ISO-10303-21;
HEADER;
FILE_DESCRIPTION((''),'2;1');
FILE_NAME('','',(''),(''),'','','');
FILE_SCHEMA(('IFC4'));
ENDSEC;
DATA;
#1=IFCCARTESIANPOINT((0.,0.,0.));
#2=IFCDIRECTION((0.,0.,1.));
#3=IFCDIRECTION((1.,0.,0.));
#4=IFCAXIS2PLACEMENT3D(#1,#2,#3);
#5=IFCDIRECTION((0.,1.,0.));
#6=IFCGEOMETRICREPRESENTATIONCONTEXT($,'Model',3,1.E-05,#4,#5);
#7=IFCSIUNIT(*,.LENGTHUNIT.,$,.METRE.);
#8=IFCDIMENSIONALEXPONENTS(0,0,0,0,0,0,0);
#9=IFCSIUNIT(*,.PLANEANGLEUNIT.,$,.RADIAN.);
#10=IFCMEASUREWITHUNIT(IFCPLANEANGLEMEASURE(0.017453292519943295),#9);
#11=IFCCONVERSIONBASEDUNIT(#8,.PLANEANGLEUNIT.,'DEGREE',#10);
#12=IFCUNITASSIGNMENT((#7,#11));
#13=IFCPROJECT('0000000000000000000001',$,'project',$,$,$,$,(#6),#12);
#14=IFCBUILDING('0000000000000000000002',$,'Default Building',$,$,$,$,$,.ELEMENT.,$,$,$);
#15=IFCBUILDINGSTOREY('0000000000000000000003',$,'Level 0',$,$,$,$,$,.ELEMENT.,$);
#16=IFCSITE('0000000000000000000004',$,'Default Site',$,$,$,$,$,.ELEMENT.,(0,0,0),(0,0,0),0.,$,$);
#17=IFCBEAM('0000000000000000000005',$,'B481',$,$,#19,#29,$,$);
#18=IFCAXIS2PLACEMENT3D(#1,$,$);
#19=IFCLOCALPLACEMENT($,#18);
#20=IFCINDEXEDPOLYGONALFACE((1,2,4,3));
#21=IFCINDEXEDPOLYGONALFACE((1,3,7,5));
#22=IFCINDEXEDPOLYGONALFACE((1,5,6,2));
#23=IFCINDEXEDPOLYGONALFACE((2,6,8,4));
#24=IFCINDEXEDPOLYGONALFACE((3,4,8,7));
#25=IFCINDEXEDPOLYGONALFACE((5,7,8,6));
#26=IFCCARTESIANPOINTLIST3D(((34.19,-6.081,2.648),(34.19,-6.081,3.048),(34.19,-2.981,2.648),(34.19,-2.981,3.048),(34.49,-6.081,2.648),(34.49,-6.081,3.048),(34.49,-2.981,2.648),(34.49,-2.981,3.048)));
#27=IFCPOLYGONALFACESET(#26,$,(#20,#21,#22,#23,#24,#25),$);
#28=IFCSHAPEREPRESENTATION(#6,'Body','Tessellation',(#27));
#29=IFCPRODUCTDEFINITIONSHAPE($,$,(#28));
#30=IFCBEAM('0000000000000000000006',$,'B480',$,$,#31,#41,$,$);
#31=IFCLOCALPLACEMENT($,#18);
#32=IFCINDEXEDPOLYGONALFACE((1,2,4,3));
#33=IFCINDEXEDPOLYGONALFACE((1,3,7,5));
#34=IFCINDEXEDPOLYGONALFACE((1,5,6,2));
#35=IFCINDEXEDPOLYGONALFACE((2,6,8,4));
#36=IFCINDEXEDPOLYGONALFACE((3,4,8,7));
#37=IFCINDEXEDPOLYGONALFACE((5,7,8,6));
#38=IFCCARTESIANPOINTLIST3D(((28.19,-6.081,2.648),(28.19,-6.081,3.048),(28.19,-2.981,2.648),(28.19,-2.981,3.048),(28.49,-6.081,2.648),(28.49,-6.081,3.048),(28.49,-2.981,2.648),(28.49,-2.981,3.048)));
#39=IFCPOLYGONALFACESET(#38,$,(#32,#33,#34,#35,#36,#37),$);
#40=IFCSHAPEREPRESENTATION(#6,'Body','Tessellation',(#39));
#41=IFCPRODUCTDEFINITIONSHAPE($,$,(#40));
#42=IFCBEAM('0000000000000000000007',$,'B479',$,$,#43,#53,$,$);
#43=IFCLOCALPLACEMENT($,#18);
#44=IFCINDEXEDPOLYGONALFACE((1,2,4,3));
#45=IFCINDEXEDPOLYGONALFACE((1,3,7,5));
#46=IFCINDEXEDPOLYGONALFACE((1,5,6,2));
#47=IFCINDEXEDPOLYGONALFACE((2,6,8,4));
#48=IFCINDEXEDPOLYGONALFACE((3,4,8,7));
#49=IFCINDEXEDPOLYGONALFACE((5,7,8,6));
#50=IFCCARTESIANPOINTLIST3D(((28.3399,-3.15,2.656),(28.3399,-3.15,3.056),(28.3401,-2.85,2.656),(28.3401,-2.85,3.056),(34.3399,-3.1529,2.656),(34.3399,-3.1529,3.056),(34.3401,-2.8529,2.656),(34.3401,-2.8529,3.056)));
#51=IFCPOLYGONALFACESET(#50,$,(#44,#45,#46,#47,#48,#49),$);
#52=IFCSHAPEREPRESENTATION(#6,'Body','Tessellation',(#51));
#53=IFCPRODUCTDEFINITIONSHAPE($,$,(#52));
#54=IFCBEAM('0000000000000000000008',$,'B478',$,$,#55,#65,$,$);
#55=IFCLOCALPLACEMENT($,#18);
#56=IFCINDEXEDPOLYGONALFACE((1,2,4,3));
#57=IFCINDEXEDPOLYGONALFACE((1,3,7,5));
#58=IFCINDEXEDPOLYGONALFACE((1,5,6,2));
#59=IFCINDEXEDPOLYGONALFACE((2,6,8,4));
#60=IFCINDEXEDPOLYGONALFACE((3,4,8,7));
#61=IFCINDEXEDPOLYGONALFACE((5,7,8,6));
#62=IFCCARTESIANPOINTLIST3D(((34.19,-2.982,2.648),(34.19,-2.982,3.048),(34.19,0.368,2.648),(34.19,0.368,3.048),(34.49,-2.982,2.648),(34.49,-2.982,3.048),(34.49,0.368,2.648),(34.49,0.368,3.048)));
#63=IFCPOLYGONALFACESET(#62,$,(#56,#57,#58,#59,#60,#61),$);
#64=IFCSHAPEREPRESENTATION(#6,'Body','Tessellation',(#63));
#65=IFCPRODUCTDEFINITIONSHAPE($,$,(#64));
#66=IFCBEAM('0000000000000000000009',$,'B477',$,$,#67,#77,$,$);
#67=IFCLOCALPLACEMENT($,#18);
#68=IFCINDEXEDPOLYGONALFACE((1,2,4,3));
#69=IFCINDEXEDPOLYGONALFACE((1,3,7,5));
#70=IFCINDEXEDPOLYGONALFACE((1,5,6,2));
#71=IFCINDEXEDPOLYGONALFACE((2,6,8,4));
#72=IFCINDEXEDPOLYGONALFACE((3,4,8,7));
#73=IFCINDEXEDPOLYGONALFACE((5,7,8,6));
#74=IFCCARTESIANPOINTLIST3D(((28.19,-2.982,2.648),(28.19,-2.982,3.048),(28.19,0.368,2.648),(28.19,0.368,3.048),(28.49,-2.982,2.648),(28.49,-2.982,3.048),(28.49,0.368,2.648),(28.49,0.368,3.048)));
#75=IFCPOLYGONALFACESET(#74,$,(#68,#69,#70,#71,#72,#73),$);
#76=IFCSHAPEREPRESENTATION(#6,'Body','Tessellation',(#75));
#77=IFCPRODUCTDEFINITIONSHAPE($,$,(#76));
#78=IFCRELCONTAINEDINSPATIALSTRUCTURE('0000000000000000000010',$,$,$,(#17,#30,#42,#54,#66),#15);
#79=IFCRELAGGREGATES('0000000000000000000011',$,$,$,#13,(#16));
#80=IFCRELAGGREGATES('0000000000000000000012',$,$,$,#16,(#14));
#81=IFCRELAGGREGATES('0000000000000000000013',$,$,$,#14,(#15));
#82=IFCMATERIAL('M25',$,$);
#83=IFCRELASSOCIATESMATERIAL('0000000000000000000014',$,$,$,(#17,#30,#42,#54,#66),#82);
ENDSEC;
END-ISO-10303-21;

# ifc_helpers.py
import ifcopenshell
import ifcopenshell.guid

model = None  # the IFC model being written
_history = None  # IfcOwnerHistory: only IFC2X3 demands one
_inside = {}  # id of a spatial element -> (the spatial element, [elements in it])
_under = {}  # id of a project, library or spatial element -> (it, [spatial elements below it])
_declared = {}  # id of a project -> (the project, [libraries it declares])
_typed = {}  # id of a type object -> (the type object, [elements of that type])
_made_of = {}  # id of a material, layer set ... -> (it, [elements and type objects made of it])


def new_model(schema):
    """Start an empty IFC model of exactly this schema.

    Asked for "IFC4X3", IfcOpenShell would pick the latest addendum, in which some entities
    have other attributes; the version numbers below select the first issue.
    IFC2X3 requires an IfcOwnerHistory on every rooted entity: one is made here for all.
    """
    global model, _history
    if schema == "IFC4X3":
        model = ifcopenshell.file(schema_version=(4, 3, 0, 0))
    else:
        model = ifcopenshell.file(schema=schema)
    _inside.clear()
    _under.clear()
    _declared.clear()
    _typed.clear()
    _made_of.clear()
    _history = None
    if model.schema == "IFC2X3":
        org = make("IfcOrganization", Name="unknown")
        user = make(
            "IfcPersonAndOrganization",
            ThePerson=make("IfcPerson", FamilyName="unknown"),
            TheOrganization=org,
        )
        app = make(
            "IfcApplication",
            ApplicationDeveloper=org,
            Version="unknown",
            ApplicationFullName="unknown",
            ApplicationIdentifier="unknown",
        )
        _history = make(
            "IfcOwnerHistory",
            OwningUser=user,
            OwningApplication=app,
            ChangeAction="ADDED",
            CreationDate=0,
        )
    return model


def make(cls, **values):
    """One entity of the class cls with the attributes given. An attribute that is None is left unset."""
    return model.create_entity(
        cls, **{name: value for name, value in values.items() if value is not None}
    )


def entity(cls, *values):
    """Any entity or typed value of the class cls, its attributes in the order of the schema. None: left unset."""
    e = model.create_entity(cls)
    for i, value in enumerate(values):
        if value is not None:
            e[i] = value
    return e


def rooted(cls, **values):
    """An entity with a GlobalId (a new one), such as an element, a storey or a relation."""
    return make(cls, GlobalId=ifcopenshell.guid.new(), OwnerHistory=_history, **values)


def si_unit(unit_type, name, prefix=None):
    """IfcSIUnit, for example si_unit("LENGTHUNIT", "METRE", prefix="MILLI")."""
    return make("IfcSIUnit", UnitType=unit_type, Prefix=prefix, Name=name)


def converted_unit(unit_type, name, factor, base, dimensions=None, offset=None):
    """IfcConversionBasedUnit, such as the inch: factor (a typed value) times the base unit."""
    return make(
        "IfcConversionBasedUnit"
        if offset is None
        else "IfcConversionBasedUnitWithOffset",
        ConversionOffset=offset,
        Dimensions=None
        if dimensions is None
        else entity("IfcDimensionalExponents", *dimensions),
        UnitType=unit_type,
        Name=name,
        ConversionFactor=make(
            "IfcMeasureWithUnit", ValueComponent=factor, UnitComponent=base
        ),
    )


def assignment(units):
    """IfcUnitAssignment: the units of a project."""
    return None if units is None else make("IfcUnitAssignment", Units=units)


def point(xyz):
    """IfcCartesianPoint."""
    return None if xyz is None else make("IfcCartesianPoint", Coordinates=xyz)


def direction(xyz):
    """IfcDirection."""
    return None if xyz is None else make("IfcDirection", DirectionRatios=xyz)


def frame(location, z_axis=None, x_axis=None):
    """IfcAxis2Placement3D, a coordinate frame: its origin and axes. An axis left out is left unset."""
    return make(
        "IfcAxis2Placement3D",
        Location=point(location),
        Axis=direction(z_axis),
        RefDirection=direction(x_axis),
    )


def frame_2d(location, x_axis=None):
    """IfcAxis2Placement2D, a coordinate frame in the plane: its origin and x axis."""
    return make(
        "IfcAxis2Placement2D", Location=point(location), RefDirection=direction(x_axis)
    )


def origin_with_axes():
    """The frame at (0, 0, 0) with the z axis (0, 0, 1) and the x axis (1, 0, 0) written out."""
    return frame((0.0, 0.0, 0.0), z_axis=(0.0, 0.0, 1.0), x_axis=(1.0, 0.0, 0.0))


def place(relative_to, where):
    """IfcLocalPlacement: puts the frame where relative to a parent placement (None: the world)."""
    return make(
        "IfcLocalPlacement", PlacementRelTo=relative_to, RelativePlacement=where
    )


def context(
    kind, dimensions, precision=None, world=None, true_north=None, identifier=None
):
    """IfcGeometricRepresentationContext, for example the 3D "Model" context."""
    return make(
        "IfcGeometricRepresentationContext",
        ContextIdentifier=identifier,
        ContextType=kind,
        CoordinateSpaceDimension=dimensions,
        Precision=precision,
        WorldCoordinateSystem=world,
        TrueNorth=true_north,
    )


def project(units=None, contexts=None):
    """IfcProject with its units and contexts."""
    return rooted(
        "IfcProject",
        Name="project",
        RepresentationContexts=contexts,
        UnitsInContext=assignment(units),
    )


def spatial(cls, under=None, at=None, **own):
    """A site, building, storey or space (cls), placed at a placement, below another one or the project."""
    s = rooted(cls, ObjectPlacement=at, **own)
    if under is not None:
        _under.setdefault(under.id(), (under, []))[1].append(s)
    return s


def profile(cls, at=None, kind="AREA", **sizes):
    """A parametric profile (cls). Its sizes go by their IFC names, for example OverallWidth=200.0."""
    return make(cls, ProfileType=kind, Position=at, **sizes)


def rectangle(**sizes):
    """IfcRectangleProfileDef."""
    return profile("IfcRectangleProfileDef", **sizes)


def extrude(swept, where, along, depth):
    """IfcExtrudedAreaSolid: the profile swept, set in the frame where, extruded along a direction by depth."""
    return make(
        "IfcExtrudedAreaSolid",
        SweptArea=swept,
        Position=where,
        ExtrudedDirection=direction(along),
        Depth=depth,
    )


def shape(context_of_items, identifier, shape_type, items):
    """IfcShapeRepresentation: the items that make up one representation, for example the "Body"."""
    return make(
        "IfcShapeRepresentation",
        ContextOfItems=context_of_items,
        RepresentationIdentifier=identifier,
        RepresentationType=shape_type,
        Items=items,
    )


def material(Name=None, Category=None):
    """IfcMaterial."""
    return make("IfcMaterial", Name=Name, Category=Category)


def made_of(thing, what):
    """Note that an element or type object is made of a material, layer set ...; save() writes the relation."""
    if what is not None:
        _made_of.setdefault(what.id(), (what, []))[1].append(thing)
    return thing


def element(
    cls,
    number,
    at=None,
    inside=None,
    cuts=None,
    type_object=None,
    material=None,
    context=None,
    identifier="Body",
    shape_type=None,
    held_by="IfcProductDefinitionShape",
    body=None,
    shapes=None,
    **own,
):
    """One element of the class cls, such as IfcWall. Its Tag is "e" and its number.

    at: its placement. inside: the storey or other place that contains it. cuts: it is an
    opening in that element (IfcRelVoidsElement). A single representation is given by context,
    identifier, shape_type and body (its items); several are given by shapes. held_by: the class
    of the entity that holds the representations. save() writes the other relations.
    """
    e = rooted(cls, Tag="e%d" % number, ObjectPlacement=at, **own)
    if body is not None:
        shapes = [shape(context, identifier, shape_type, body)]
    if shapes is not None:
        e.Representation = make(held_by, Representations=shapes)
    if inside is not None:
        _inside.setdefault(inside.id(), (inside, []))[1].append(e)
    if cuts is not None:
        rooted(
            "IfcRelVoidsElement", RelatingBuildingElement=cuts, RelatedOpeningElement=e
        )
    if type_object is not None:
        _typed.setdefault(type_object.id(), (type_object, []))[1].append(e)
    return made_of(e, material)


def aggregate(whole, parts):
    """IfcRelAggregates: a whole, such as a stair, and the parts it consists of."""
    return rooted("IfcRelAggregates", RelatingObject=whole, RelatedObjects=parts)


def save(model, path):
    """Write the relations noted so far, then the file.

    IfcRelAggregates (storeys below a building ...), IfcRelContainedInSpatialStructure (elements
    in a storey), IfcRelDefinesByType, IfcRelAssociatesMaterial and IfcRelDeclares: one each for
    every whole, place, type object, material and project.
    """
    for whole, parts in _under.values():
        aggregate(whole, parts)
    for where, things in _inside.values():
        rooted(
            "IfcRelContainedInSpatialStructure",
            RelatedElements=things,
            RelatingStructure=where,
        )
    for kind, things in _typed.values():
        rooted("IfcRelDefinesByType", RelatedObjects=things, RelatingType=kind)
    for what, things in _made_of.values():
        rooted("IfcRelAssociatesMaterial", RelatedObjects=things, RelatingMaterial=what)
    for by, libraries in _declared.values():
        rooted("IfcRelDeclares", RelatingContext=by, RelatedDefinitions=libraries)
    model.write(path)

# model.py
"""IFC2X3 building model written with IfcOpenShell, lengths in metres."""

from ifc_helpers import new_model, entity, si_unit, converted_unit, direction, frame, frame_2d, origin_with_axes, place, context, project, spatial, rectangle, extrude, material, element, save


model = new_model("IFC2X3")

# Units and contexts
model_context = context("Model", 3, precision=1e-05, world=origin_with_axes(), true_north=direction((0.0, 1.0, 0.0)))
ifc_project = project(units=[si_unit("LENGTHUNIT", "METRE"), converted_unit("PLANEANGLEUNIT", "DEGREE", entity("IfcPlaneAngleMeasure", 0.017453292519943295), si_unit("PLANEANGLEUNIT", "RADIAN"), dimensions=[0, 0, 0, 0, 0, 0, 0])], contexts=[model_context])

# Site, building, storey
site = spatial("IfcSite", under=ifc_project, Name="Default Site", CompositionType="ELEMENT", RefLatitude=(0, 0, 0), RefLongitude=(0, 0, 0), RefElevation=0.0)
building = spatial("IfcBuilding", under=site, Name="Default Building", CompositionType="ELEMENT")
storey = spatial("IfcBuildingStorey", under=building, Name="Level 0", CompositionType="ELEMENT")

# Beams
ifc_material = material(Name="M25")
placement = place(None, origin_with_axes())
element("IfcBeam", 1, at=placement, inside=storey, material=ifc_material, Name="B481", context=model_context, shape_type="SweptSolid", body=[
    extrude(rectangle(XDim=0.3, YDim=0.4, at=frame_2d((0.0, 0.0), x_axis=(0.0, 1.0, 0.0))), frame((34.34, -6.081, 2.848), z_axis=(0.0, 1.0, 0.0), x_axis=(0.0, 0.0, -1.0)), (0.0, 0.0, 1.0), 3.1),
])
element("IfcBeam", 2, at=placement, inside=storey, material=ifc_material, Name="B480", context=model_context, shape_type="SweptSolid", body=[
    extrude(rectangle(XDim=0.3, YDim=0.4, at=frame_2d((0.0, 0.0), x_axis=(0.0, 1.0, 0.0))), frame((28.34, -6.081, 2.848), z_axis=(0.0, 1.0, 0.0), x_axis=(0.0, 0.0, -1.0)), (0.0, 0.0, 1.0), 3.1),
])
element("IfcBeam", 3, at=placement, inside=storey, material=ifc_material, Name="B479", context=model_context, shape_type="SweptSolid", body=[
    extrude(rectangle(XDim=0.3, YDim=0.4, at=frame_2d((0.0, 0.0), x_axis=(0.0, 1.0, 0.0))), frame((28.34, -3.0, 2.856), z_axis=(1.0, -0.000487, 0.0), x_axis=(0.0, 0.0, -1.0)), (0.0, 0.0, 1.0), 6.0),
])
element("IfcBeam", 4, at=placement, inside=storey, material=ifc_material, Name="B478", context=model_context, shape_type="SweptSolid", body=[
    extrude(rectangle(XDim=0.3, YDim=0.4, at=frame_2d((0.0, 0.0), x_axis=(0.0, 1.0, 0.0))), frame((34.34, -2.982, 2.848), z_axis=(0.0, 1.0, 0.0), x_axis=(0.0, 0.0, -1.0)), (0.0, 0.0, 1.0), 3.35),
])
element("IfcBeam", 5, at=placement, inside=storey, material=ifc_material, Name="B477", context=model_context, shape_type="SweptSolid", body=[
    extrude(rectangle(XDim=0.3, YDim=0.4, at=frame_2d((0.0, 0.0), x_axis=(0.0, 1.0, 0.0))), frame((28.34, -2.982, 2.848), z_axis=(0.0, 1.0, 0.0), x_axis=(0.0, 0.0, -1.0)), (0.0, 0.0, 1.0), 3.35),
])

save(model, "model.ifc")
